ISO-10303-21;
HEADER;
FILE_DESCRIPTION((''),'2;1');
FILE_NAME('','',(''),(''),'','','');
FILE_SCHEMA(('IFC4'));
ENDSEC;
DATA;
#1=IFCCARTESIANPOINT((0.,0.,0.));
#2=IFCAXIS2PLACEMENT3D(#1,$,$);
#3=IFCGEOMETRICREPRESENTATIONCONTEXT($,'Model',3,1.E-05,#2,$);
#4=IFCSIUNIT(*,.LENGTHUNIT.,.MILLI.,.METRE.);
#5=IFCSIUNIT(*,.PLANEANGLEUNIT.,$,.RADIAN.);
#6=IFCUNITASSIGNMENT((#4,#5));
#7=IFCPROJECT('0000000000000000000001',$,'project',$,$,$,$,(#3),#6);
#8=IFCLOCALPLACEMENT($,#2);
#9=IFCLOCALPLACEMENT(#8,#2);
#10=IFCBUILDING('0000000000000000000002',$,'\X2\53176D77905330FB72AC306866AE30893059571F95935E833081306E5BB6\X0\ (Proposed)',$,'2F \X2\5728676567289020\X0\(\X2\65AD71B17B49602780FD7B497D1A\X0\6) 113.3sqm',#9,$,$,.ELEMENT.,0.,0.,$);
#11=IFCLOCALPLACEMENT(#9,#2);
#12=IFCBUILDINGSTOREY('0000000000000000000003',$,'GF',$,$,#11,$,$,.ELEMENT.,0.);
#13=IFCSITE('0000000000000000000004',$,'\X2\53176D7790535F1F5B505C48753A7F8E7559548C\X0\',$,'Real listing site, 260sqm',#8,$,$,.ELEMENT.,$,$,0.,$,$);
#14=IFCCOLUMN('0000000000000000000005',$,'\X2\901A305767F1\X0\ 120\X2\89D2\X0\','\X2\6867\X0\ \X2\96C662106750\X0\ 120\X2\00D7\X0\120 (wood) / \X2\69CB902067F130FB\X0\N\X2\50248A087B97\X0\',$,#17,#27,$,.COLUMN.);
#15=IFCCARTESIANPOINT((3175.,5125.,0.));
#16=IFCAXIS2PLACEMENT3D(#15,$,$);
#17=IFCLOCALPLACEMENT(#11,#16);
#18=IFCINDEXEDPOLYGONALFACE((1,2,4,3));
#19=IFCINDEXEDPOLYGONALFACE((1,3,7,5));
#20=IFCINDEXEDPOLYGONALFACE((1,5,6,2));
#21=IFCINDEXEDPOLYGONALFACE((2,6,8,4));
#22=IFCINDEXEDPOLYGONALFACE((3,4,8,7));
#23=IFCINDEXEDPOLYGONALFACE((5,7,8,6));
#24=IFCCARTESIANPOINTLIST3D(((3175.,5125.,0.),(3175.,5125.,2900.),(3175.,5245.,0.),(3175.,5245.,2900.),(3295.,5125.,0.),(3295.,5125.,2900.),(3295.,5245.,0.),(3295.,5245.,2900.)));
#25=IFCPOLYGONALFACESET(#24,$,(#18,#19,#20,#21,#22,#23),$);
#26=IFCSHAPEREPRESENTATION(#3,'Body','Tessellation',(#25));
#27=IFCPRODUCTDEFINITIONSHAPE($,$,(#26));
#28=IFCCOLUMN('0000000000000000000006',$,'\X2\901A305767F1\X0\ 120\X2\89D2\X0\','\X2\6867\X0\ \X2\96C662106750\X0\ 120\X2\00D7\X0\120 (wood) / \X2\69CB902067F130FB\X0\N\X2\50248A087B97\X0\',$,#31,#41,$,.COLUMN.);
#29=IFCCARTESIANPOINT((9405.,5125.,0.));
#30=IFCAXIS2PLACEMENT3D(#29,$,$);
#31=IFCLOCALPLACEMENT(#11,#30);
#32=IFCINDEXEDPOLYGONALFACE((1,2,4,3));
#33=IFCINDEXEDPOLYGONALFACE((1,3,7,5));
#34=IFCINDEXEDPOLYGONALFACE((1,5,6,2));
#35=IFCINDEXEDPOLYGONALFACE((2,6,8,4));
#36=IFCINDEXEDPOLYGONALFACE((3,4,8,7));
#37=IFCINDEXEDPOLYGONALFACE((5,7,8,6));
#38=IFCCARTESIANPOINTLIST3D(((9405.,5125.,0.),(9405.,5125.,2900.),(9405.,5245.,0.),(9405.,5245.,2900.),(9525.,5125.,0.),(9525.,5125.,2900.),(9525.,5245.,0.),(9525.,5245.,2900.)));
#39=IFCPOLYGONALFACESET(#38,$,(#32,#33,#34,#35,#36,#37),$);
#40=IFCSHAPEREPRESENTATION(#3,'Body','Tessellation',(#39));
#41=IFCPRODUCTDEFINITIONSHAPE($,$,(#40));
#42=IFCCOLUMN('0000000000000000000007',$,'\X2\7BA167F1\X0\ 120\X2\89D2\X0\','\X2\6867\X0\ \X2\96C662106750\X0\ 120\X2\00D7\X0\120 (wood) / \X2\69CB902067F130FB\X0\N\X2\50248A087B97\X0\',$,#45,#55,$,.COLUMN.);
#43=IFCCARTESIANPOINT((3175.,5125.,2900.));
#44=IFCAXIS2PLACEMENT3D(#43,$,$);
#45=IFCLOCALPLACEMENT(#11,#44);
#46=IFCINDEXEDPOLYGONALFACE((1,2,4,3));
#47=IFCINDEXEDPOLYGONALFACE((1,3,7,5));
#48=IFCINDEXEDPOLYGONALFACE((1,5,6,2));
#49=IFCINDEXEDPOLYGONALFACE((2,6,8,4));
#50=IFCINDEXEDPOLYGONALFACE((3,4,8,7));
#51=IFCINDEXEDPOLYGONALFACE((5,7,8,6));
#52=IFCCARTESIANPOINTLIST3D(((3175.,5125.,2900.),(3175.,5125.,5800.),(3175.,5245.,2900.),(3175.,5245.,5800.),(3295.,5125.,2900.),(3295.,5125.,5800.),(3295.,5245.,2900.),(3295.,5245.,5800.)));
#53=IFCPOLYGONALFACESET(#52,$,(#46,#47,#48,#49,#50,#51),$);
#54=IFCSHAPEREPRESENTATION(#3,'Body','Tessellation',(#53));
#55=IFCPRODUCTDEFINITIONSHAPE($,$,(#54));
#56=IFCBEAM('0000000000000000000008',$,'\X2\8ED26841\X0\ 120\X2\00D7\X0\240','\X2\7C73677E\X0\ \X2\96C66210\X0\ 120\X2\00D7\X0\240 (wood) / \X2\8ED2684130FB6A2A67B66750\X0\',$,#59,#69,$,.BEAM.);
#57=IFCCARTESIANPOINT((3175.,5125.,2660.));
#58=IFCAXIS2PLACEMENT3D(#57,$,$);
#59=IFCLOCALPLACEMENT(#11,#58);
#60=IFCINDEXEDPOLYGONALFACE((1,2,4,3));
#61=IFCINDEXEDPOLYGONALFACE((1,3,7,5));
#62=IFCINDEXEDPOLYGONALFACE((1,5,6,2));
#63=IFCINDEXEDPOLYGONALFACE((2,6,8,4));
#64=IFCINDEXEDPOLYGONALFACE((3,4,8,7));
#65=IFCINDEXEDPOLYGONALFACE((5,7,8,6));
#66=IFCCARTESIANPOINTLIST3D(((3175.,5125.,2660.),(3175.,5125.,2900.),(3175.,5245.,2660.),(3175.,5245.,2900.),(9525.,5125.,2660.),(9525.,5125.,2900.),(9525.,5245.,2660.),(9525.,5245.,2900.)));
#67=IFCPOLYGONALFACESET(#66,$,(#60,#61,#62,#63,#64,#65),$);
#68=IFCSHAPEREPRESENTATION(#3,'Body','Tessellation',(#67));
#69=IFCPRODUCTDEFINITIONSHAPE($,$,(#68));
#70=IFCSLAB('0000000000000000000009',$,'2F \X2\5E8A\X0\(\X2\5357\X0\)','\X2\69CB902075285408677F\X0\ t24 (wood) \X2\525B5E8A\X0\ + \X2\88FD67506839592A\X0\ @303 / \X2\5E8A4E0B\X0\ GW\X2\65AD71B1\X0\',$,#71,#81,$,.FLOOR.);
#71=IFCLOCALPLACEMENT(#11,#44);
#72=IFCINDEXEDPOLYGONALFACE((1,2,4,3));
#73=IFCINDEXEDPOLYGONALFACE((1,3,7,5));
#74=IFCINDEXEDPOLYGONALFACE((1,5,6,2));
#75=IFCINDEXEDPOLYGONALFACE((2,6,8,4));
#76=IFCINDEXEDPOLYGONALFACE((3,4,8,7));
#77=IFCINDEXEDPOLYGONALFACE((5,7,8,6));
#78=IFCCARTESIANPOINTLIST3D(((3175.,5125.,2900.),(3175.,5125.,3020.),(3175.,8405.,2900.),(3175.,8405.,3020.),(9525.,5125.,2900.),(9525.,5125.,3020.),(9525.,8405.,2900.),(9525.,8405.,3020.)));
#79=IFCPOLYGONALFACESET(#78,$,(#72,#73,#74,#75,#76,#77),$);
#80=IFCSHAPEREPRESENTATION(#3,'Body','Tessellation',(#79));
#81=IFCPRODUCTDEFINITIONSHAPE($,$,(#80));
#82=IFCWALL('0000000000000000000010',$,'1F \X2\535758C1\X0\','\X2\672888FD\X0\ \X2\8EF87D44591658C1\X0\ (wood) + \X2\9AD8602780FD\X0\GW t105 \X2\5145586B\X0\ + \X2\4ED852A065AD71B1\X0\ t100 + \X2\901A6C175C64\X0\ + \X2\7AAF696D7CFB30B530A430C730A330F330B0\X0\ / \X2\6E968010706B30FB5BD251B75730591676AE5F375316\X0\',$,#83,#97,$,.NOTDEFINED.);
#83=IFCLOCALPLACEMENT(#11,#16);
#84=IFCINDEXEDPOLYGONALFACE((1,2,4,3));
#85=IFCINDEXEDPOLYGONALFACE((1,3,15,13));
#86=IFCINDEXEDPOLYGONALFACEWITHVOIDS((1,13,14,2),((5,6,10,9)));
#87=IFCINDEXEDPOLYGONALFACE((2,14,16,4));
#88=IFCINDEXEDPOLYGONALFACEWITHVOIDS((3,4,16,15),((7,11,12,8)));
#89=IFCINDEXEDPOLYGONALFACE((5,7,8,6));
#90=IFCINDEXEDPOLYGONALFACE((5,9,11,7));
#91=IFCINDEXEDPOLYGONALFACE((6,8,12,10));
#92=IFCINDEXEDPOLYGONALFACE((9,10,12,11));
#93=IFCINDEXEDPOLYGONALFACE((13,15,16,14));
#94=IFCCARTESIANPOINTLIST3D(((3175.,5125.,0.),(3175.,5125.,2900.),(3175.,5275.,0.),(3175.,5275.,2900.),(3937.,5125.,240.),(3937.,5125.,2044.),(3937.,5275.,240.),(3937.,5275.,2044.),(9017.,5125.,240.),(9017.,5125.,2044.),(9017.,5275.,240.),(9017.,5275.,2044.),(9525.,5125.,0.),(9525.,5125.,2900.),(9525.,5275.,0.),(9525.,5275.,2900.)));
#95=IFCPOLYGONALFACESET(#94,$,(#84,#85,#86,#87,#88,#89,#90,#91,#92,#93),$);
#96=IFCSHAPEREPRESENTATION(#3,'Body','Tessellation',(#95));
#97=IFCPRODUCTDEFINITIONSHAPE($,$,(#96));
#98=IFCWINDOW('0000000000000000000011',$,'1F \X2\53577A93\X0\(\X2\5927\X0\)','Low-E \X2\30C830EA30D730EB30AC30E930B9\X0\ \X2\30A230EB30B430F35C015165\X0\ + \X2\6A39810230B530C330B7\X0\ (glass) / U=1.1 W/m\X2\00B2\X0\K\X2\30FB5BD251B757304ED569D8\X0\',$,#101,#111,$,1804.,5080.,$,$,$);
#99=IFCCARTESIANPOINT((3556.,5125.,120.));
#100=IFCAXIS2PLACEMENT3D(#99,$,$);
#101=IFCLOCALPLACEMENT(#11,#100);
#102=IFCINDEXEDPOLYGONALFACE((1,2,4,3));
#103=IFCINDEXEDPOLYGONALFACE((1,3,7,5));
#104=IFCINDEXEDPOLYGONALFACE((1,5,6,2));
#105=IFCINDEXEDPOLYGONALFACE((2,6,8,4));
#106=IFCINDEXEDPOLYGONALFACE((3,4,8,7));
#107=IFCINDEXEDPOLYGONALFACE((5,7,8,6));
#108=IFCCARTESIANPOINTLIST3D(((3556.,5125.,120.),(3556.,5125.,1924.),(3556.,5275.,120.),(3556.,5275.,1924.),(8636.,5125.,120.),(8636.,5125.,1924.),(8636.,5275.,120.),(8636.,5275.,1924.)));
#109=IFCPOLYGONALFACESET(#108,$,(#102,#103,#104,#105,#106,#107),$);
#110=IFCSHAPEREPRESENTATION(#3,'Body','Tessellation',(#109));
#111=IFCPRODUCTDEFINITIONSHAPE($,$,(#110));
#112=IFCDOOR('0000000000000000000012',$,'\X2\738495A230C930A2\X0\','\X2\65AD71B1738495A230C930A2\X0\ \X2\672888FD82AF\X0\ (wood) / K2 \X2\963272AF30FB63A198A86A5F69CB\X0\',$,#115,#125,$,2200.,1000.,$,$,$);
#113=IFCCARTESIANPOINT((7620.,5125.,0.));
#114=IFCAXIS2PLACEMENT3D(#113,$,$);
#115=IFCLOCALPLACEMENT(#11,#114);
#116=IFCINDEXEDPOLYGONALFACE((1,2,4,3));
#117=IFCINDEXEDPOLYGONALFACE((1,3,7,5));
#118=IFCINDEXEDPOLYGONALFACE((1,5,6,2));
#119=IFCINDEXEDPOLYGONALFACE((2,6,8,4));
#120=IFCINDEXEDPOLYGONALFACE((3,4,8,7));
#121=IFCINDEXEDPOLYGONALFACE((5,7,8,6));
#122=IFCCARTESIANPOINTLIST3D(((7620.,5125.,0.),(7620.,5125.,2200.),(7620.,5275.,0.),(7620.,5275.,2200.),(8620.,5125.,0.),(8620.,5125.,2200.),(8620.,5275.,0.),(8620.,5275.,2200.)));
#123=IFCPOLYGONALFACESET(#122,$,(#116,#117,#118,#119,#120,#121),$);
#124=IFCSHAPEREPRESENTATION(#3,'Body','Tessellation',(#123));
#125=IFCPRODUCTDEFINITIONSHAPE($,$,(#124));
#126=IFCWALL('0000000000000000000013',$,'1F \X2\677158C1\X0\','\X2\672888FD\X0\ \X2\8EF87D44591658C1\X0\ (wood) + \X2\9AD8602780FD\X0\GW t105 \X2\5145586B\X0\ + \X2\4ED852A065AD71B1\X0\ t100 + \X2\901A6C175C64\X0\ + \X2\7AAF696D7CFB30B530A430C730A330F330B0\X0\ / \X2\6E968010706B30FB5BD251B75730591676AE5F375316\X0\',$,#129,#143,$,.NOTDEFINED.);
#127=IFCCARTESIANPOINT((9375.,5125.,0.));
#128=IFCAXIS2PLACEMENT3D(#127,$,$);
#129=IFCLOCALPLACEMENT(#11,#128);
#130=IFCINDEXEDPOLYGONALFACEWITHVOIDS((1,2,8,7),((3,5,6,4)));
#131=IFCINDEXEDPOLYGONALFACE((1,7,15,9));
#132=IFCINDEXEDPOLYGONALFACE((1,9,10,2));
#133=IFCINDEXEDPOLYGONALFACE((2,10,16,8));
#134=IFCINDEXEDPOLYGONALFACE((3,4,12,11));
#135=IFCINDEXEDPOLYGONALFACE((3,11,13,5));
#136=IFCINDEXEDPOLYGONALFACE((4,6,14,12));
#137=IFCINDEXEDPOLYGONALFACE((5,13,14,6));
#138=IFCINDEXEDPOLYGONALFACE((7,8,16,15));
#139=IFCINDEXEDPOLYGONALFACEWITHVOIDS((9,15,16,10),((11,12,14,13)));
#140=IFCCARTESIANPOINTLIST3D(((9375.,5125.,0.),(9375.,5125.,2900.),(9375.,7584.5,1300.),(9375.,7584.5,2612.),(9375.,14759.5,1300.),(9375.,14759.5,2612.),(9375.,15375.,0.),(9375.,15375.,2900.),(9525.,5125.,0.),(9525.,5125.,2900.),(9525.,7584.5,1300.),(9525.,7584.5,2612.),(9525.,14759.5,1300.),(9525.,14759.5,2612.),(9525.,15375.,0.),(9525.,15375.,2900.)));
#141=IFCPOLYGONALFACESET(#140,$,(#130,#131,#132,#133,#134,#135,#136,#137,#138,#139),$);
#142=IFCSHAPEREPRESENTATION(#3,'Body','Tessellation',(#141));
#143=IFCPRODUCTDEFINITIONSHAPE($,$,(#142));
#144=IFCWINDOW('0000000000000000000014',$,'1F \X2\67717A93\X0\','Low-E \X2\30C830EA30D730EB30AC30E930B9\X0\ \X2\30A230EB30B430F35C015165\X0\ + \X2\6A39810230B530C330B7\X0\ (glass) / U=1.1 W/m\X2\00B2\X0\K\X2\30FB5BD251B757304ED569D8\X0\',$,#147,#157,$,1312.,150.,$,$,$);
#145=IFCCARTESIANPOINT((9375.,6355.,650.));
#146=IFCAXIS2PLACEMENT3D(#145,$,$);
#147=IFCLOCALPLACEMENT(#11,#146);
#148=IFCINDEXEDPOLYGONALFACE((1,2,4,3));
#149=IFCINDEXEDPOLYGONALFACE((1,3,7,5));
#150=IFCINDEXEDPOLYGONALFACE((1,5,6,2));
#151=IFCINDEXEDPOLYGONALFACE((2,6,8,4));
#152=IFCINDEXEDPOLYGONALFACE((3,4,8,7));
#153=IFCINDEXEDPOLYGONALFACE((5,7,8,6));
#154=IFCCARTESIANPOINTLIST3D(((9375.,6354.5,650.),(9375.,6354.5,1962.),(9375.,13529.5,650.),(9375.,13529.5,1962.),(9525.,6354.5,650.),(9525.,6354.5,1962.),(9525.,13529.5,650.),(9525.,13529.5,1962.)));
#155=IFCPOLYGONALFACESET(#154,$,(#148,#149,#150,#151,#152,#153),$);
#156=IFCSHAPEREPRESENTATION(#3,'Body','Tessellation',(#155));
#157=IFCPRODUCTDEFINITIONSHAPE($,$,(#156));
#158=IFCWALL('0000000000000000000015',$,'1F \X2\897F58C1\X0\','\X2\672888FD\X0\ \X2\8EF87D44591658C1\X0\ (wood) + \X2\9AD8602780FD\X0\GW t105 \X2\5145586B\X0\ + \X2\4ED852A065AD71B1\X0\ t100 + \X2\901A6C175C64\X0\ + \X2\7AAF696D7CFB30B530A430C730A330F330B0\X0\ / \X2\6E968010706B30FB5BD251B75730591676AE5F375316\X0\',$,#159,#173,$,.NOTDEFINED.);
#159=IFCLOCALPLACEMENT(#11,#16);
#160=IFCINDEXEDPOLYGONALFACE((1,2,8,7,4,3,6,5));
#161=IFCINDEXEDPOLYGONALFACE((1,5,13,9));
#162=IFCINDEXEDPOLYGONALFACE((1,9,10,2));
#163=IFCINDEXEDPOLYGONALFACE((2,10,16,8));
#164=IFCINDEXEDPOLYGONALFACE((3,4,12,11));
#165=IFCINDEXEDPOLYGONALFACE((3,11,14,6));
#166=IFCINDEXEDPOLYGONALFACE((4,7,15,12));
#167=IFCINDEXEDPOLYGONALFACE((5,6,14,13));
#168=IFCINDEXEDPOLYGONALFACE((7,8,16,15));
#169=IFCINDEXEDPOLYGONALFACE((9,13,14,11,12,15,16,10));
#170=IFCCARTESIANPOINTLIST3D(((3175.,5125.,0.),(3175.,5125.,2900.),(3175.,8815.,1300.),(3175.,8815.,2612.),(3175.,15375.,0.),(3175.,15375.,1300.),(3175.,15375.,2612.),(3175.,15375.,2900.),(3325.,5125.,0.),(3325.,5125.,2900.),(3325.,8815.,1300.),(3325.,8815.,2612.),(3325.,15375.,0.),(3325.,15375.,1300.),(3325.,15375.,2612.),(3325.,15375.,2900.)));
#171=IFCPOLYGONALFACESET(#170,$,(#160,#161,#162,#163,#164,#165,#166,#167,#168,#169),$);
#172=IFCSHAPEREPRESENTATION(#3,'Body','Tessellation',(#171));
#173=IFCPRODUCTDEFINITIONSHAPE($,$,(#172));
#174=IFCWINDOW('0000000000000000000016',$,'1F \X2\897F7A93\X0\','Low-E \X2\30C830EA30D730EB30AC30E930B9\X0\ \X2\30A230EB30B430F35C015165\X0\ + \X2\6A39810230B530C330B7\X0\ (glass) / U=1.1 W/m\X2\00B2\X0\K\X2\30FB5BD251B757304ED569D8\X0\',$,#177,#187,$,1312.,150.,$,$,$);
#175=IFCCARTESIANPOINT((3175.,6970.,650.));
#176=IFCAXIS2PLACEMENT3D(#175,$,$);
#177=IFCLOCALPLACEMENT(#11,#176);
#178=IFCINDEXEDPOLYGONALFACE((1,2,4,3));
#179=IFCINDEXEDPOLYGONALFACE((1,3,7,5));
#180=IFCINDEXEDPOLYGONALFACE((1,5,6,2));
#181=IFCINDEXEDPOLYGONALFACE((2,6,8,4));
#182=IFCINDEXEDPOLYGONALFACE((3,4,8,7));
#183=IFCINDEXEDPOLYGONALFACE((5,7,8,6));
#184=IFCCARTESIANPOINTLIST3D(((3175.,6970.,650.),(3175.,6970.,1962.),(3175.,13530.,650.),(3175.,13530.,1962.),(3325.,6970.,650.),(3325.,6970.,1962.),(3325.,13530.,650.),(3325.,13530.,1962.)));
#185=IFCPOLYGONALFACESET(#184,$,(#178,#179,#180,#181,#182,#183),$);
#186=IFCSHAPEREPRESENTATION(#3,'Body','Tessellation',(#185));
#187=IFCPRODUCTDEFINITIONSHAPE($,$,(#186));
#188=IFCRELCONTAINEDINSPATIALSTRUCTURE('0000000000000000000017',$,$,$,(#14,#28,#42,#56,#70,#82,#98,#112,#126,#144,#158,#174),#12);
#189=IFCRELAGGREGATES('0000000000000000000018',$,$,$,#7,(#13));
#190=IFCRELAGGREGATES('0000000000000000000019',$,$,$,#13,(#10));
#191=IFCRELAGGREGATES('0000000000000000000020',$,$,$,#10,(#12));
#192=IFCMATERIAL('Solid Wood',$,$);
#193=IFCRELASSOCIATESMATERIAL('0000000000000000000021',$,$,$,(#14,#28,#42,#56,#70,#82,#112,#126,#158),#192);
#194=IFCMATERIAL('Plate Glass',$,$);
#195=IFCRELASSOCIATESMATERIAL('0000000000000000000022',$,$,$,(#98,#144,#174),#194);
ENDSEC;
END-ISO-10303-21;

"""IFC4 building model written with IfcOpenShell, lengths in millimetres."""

from ifc_helpers import new_model, si_unit, frame, frame_2d, origin, place, context, project, spatial, rectangle, extrude, material, element, fill, save


model = new_model("IFC4")

# Units and contexts
model_context = context("Model", 3, precision=1e-05, world=origin())
ifc_project = project(units=[si_unit("LENGTHUNIT", "METRE", prefix="MILLI"), si_unit("PLANEANGLEUNIT", "RADIAN")], contexts=[model_context])

# Site, building, storey
site_placement = place(None, origin())
site = spatial("IfcSite", under=ifc_project, at=site_placement, Name="北海道弟子屈町美留和", ObjectType="Real listing site, 260sqm", CompositionType="ELEMENT", RefElevation=0.0)
building_placement = place(site_placement, origin())
building = spatial("IfcBuilding", under=site, at=building_placement, Name="北海道・犬と暮らす土間広めの家 (Proposed)", ObjectType="2F 在来木造(断熱等性能等級6) 113.3sqm", CompositionType="ELEMENT", ElevationOfRefHeight=0.0, ElevationOfTerrain=0.0)
storey_placement = place(building_placement, origin())
storey = spatial("IfcBuildingStorey", under=building, at=storey_placement, Name="GF", CompositionType="ELEMENT", Elevation=0.0)

# Columns
ifc_material_1 = material(Name="Solid Wood")
column_1_placement = place(storey_placement, frame((3175.0, 5125.0, 0.0)))
element("IfcColumn", 1, at=column_1_placement, inside=storey, material=ifc_material_1, Name="通し柱 120角", Description="桧 集成材 120×120 (wood) / 構造柱・N値計算", PredefinedType="COLUMN", context=model_context, shape_type="SweptSolid", body=[
    extrude(rectangle(XDim=120.0, YDim=120.0, at=frame_2d((60.0, 60.0))), frame((3175.0, 5125.0, 0.0)), (0.0, 0.0, 1.0), 2900.0),
])
column_2_placement = place(storey_placement, frame((9405.0, 5125.0, 0.0)))
element("IfcColumn", 2, at=column_2_placement, inside=storey, material=ifc_material_1, Name="通し柱 120角", Description="桧 集成材 120×120 (wood) / 構造柱・N値計算", PredefinedType="COLUMN", context=model_context, shape_type="SweptSolid", body=[
    extrude(rectangle(XDim=120.0, YDim=120.0, at=frame_2d((60.0, 60.0))), frame((9405.0, 5125.0, 0.0)), (0.0, 0.0, 1.0), 2900.0),
])
column_3_placement = place(storey_placement, frame((3175.0, 5125.0, 2900.0)))
element("IfcColumn", 3, at=column_3_placement, inside=storey, material=ifc_material_1, Name="管柱 120角", Description="桧 集成材 120×120 (wood) / 構造柱・N値計算", PredefinedType="COLUMN", context=model_context, shape_type="SweptSolid", body=[
    extrude(rectangle(XDim=120.0, YDim=120.0, at=frame_2d((60.0, 60.0))), frame((3175.0, 5125.0, 2900.0)), (0.0, 0.0, 1.0), 2900.0),
])

# Beam
beam_1_placement = place(storey_placement, frame((3175.0, 5125.0, 2660.0)))
element("IfcBeam", 4, at=beam_1_placement, inside=storey, material=ifc_material_1, Name="軒桁 120×240", Description="米松 集成 120×240 (wood) / 軒桁・横架材", PredefinedType="BEAM", context=model_context, shape_type="SweptSolid", body=[
    extrude(rectangle(XDim=6350.0, YDim=120.0, at=frame_2d((3175.0, 60.0))), frame((3175.0, 5125.0, 2660.0)), (0.0, 0.0, 1.0), 240.0),
])

# Slab
slab_1_placement = place(storey_placement, frame((3175.0, 5125.0, 2900.0)))
element("IfcSlab", 5, at=slab_1_placement, inside=storey, material=ifc_material_1, Name="2F 床(南)", Description="構造用合板 t24 (wood) 剛床 + 製材根太 @303 / 床下 GW断熱", PredefinedType="FLOOR", context=model_context, shape_type="SweptSolid", body=[
    extrude(rectangle(XDim=6350.0, YDim=3280.0, at=frame_2d((3175.0, 1640.0))), frame((3175.0, 5125.0, 2900.0)), (0.0, 0.0, 1.0), 120.0),
])

# Wall, openings, window, door
wall_1_placement = place(storey_placement, frame((3175.0, 5125.0, 0.0)))
wall_1 = element("IfcWall", 6, at=wall_1_placement, inside=storey, material=ifc_material_1, Name="1F 南壁", Description="木製 軸組外壁 (wood) + 高性能GW t105 充填 + 付加断熱 t100 + 通気層 + 窯業系サイディング / 準耐火・寒冷地外皮強化", PredefinedType="NOTDEFINED", context=model_context, shape_type="SweptSolid", body=[
    extrude(rectangle(XDim=6350.0, YDim=150.0, at=frame_2d((3175.0, 75.0))), frame((3175.0, 5125.0, 0.0)), (0.0, 0.0, 1.0), 2900.0),
])
opening_1_placement = place(storey_placement, frame((3556.0, 5125.0, 120.0)))
opening_1 = element("IfcOpeningElement", 7, at=opening_1_placement, cuts=wall_1, PredefinedType="NOTDEFINED", context=model_context, shape_type="SweptSolid", body=[
    extrude(rectangle(XDim=5080.0, YDim=150.0, at=frame_2d((2540.0, 75.0))), frame((3556.0, 5125.0, 120.0)), (0.0, 0.0, 1.0), 1804.0),
])
opening_2_placement = place(storey_placement, frame((7620.0, 5125.0, 0.0)))
opening_2 = element("IfcOpeningElement", 8, at=opening_2_placement, cuts=wall_1, PredefinedType="NOTDEFINED", context=model_context, shape_type="SweptSolid", body=[
    extrude(rectangle(XDim=1000.0, YDim=150.0, at=frame_2d((500.0, 75.0))), frame((7620.0, 5125.0, 0.0)), (0.0, 0.0, 1.0), 2200.0),
])
ifc_material_2 = material(Name="Plate Glass")
window_1_placement = place(storey_placement, frame((3556.0, 5125.0, 120.0)))
window_1 = element("IfcWindow", 9, at=window_1_placement, inside=storey, material=ifc_material_2, Name="1F 南窓(大)", Description="Low-E トリプルガラス アルゴン封入 + 樹脂サッシ (glass) / U=1.1 W/m²K・寒冷地仕様", OverallHeight=1804.0, OverallWidth=5080.0, context=model_context, shape_type="SweptSolid", body=[
    extrude(rectangle(XDim=5080.0, YDim=150.0, at=frame_2d((2540.0, 75.0))), frame((3556.0, 5125.0, 120.0)), (0.0, 0.0, 1.0), 1804.0),
])
fill(opening_1, window_1)
door_placement = place(storey_placement, frame((7620.0, 5125.0, 0.0)))
door = element("IfcDoor", 10, at=door_placement, inside=storey, material=ifc_material_1, Name="玄関ドア", Description="断熱玄関ドア 木製芯 (wood) / K2 防犯・採風機構", OverallHeight=2200.0, OverallWidth=1000.0, context=model_context, shape_type="SweptSolid", body=[
    extrude(rectangle(XDim=1000.0, YDim=150.0, at=frame_2d((500.0, 75.0))), frame((7620.0, 5125.0, 0.0)), (0.0, 0.0, 1.0), 2200.0),
])
fill(opening_2, door)

# Walls, openings, windows
wall_2_placement = place(storey_placement, frame((9375.0, 5125.0, 0.0)))
wall_2 = element("IfcWall", 11, at=wall_2_placement, inside=storey, material=ifc_material_1, Name="1F 東壁", Description="木製 軸組外壁 (wood) + 高性能GW t105 充填 + 付加断熱 t100 + 通気層 + 窯業系サイディング / 準耐火・寒冷地外皮強化", PredefinedType="NOTDEFINED", context=model_context, shape_type="SweptSolid", body=[
    extrude(rectangle(XDim=150.0, YDim=10250.0, at=frame_2d((75.0, 5125.0))), frame((9375.0, 5125.0, 0.0)), (0.0, 0.0, 1.0), 2900.0),
])
opening_3_placement = place(storey_placement, frame((9375.0, 6355.0, 650.0)))
opening_3 = element("IfcOpeningElement", 12, at=opening_3_placement, cuts=wall_2, PredefinedType="NOTDEFINED", context=model_context, shape_type="SweptSolid", body=[
    extrude(rectangle(XDim=150.0, YDim=7175.0, at=frame_2d((75.0, 3587.0))), frame((9375.0, 6355.0, 650.0)), (0.0, 0.0, 1.0), 1312.0),
])
window_2_placement = place(storey_placement, frame((9375.0, 6355.0, 650.0)))
window_2 = element("IfcWindow", 13, at=window_2_placement, inside=storey, material=ifc_material_2, Name="1F 東窓", Description="Low-E トリプルガラス アルゴン封入 + 樹脂サッシ (glass) / U=1.1 W/m²K・寒冷地仕様", OverallHeight=1312.0, OverallWidth=150.0, context=model_context, shape_type="SweptSolid", body=[
    extrude(rectangle(XDim=150.0, YDim=7175.0, at=frame_2d((75.0, 3587.0))), frame((9375.0, 6355.0, 650.0)), (0.0, 0.0, 1.0), 1312.0),
])
fill(opening_3, window_2)
wall_3_placement = place(storey_placement, frame((3175.0, 5125.0, 0.0)))
wall_3 = element("IfcWall", 14, at=wall_3_placement, inside=storey, material=ifc_material_1, Name="1F 西壁", Description="木製 軸組外壁 (wood) + 高性能GW t105 充填 + 付加断熱 t100 + 通気層 + 窯業系サイディング / 準耐火・寒冷地外皮強化", PredefinedType="NOTDEFINED", context=model_context, shape_type="SweptSolid", body=[
    extrude(rectangle(XDim=150.0, YDim=10250.0, at=frame_2d((75.0, 5125.0))), frame((3175.0, 5125.0, 0.0)), (0.0, 0.0, 1.0), 2900.0),
])
opening_4_placement = place(storey_placement, frame((3175.0, 6970.0, 650.0)))
opening_4 = element("IfcOpeningElement", 15, at=opening_4_placement, cuts=wall_3, PredefinedType="NOTDEFINED", context=model_context, shape_type="SweptSolid", body=[
    extrude(rectangle(XDim=150.0, YDim=6560.0, at=frame_2d((75.0, 3280.0))), frame((3175.0, 6970.0, 650.0)), (0.0, 0.0, 1.0), 1312.0),
])
window_3_placement = place(storey_placement, frame((3175.0, 6970.0, 650.0)))
window_3 = element("IfcWindow", 16, at=window_3_placement, inside=storey, material=ifc_material_2, Name="1F 西窓", Description="Low-E トリプルガラス アルゴン封入 + 樹脂サッシ (glass) / U=1.1 W/m²K・寒冷地仕様", OverallHeight=1312.0, OverallWidth=150.0, context=model_context, shape_type="SweptSolid", body=[
    extrude(rectangle(XDim=150.0, YDim=6560.0, at=frame_2d((75.0, 3280.0))), frame((3175.0, 6970.0, 650.0)), (0.0, 0.0, 1.0), 1312.0),
])
fill(opening_4, window_3)

save(model, "model.ifc")
